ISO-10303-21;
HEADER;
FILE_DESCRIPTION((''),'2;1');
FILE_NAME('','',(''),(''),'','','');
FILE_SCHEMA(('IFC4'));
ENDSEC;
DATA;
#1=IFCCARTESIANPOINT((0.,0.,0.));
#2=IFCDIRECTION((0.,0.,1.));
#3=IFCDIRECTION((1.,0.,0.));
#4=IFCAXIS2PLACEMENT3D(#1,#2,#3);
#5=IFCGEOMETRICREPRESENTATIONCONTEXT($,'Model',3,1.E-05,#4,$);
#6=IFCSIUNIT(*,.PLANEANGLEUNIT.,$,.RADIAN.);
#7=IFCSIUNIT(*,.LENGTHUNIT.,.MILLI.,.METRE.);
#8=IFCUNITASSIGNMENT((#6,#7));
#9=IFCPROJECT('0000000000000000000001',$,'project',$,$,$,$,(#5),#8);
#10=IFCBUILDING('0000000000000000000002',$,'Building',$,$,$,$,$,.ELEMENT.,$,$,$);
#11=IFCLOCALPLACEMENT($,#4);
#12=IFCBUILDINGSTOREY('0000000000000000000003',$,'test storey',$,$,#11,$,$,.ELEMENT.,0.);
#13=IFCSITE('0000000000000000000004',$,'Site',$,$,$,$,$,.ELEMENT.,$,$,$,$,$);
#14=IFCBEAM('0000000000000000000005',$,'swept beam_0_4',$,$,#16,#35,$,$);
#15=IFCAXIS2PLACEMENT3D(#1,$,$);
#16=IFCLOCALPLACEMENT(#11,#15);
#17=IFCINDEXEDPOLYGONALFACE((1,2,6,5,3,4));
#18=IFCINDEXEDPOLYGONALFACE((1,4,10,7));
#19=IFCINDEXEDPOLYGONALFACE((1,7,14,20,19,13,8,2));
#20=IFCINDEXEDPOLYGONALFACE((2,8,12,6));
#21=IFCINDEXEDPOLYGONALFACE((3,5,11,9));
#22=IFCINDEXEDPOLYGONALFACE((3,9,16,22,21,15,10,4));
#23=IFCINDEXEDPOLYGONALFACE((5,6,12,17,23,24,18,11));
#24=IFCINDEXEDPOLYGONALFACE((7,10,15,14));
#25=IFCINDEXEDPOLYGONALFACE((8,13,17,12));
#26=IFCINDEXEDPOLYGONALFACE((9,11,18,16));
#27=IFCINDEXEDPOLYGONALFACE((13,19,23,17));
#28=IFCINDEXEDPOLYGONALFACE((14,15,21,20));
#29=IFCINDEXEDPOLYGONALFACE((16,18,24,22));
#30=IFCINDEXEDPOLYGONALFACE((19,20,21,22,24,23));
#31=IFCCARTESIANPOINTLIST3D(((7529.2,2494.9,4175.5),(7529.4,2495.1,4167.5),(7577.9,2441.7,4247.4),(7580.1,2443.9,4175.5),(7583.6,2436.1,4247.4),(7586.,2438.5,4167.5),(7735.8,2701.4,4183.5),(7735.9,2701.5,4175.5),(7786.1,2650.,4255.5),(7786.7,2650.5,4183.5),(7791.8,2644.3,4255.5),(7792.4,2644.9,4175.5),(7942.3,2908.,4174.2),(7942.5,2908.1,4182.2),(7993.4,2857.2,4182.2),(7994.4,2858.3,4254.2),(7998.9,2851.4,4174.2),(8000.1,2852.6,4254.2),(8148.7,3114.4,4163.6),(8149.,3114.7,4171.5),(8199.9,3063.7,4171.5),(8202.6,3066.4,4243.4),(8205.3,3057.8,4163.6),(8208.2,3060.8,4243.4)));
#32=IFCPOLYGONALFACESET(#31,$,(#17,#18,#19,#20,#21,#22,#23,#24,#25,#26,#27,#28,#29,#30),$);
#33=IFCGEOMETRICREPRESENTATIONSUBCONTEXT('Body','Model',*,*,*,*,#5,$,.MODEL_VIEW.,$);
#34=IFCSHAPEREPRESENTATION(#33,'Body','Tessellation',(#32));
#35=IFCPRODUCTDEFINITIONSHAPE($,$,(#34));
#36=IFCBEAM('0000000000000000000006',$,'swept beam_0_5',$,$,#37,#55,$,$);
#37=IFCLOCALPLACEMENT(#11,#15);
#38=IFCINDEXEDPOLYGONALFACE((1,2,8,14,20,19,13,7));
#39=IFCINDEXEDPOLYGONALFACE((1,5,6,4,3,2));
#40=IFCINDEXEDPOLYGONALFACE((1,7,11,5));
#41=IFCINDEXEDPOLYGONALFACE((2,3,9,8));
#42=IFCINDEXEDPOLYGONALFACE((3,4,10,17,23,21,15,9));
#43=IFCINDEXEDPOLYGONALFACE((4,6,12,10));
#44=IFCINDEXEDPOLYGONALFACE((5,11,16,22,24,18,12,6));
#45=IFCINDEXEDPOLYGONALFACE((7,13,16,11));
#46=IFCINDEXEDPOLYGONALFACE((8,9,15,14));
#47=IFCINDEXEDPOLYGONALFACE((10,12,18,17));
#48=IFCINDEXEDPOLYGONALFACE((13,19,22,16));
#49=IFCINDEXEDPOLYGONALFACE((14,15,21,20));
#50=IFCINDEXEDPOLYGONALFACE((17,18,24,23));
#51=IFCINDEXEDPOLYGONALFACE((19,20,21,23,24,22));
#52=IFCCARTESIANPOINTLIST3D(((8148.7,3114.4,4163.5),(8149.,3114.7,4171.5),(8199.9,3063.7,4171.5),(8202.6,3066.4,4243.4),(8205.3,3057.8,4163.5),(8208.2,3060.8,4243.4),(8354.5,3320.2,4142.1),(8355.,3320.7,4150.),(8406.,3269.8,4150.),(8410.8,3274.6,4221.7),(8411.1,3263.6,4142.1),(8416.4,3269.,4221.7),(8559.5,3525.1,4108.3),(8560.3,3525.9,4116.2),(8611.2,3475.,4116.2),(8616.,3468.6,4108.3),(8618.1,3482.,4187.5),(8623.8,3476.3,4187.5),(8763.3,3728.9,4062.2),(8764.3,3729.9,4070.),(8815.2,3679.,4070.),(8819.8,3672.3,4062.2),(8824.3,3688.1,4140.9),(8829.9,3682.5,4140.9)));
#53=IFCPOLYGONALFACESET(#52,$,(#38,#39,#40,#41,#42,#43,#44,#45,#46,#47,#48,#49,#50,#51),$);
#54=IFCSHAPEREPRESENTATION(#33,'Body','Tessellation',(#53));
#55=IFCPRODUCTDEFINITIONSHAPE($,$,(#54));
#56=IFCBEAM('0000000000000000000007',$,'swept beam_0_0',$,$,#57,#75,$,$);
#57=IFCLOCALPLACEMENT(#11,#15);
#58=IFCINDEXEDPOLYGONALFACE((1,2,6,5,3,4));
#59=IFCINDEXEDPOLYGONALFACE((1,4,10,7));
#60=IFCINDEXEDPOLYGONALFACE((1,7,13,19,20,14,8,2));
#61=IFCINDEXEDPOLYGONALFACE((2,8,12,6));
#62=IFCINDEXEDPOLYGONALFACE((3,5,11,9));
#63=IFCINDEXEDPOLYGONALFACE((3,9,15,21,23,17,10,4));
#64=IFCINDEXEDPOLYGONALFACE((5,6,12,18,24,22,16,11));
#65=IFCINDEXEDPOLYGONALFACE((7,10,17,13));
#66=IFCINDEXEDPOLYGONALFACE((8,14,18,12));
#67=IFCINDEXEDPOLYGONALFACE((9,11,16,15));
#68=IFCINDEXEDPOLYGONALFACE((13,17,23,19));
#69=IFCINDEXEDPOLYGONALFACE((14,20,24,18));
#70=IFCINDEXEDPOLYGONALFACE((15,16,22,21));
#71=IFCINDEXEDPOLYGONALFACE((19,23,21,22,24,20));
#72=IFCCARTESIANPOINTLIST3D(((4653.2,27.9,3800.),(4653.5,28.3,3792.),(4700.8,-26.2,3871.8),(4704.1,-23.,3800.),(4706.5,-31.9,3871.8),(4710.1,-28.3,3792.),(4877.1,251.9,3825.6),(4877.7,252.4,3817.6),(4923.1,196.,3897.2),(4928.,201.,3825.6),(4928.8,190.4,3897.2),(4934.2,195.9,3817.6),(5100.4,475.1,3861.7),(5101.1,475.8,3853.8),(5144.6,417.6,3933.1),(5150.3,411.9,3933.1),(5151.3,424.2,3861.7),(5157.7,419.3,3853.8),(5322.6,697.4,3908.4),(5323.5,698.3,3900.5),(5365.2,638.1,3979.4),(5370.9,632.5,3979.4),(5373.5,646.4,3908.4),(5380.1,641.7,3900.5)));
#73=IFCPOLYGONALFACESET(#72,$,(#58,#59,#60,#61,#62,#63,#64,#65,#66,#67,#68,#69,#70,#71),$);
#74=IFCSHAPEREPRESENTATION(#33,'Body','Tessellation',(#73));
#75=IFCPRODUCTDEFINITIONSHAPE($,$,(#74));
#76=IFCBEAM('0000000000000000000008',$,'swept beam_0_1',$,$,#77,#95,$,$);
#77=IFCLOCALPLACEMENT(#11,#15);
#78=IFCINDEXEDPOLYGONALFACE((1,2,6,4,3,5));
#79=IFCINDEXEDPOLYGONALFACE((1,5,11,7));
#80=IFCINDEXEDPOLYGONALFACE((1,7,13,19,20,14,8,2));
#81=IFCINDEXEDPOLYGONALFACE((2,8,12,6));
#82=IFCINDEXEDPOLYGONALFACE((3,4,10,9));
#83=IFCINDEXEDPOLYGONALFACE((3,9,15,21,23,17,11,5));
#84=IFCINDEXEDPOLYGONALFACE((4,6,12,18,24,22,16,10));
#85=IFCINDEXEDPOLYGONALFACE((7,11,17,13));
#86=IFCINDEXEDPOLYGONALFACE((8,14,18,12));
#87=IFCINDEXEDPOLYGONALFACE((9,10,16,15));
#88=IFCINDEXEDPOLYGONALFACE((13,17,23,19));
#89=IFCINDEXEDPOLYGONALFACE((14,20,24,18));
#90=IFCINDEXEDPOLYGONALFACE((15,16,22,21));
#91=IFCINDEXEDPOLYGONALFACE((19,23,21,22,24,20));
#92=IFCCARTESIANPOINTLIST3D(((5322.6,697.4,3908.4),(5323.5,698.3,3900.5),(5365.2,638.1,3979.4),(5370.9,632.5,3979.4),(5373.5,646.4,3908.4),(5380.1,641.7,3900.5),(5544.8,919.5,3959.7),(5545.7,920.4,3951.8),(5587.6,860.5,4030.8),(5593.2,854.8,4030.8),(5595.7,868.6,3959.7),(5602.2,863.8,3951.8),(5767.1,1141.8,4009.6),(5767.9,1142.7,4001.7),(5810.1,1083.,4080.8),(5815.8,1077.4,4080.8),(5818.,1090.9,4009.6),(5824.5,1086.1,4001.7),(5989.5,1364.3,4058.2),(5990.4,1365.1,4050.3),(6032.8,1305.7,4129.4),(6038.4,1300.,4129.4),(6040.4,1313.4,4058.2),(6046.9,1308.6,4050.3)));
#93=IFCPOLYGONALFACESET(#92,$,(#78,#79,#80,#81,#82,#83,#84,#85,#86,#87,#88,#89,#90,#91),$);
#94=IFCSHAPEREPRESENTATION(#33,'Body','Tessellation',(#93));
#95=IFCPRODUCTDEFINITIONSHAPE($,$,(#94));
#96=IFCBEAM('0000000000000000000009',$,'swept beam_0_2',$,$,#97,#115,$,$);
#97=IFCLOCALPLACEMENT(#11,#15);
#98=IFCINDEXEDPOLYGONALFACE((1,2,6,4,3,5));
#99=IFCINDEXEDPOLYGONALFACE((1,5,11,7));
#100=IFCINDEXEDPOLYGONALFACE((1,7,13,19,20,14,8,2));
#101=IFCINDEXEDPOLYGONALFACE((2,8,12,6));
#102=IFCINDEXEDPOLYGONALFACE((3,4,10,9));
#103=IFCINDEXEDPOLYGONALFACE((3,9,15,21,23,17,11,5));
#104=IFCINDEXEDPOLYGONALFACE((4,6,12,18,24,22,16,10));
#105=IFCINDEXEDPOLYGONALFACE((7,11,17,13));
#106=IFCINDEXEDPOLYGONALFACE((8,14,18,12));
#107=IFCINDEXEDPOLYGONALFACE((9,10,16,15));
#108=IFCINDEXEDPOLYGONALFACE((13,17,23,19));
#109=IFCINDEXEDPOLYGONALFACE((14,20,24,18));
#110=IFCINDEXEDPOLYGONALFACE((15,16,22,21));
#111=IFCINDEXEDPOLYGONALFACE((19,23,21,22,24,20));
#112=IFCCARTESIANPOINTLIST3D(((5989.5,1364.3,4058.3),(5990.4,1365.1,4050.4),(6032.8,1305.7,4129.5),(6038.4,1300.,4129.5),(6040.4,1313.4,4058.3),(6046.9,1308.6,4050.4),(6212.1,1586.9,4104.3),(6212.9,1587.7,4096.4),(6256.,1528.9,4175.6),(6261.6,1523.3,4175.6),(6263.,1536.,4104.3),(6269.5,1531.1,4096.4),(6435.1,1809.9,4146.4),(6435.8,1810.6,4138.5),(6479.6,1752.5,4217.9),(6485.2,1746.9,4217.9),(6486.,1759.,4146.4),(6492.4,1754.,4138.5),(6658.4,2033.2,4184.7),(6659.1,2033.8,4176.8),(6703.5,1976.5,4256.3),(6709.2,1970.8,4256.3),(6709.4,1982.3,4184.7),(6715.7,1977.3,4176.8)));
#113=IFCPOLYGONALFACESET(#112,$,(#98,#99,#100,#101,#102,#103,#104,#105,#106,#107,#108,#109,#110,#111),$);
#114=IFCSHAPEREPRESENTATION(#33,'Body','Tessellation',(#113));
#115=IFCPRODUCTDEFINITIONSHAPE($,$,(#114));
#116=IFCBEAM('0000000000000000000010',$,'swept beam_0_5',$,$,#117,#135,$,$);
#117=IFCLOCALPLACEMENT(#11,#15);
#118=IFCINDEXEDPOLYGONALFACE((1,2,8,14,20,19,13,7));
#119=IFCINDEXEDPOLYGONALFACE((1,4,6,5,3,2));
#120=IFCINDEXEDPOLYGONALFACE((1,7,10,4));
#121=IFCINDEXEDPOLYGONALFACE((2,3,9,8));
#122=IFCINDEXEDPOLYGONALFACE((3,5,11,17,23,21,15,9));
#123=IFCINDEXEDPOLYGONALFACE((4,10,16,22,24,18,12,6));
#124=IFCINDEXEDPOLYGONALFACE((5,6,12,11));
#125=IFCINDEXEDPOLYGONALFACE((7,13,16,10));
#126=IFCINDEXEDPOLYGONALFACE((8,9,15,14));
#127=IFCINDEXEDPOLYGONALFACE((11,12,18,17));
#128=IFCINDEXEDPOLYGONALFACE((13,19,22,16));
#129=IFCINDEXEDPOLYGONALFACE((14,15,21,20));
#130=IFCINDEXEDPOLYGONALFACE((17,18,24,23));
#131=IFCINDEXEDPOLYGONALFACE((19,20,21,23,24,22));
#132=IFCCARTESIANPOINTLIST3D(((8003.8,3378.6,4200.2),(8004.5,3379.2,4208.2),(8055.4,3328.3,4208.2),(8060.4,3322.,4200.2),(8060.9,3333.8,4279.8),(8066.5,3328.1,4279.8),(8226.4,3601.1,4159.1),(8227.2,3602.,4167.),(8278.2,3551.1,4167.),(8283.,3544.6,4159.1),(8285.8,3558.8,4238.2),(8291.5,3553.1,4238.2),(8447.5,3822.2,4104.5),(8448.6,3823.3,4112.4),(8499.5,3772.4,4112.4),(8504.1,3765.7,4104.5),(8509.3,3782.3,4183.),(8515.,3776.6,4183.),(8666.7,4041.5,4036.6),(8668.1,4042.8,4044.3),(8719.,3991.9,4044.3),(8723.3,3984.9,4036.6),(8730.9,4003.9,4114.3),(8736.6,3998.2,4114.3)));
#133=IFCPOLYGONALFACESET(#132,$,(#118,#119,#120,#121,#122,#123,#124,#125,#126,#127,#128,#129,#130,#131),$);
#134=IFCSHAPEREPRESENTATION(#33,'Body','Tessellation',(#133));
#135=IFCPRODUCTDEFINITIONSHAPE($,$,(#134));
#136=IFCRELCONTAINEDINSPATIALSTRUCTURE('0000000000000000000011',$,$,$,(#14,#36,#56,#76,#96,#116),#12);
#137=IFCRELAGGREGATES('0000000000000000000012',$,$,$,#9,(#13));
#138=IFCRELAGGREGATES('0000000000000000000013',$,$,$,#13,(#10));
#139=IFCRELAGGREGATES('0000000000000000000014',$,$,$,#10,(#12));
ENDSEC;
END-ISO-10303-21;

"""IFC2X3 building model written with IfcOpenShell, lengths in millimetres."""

from ifc_helpers import new_model, entity, si_unit, origin_with_axes, place, context, subcontext, project, spatial, element, save


model = new_model("IFC2X3")

# Units and contexts
model_context = context("Model", 3, precision=1e-05, world=origin_with_axes())
body_context = subcontext(model_context, "Body", "Model", "MODEL_VIEW")
ifc_project = project(units=[si_unit("PLANEANGLEUNIT", "RADIAN"), si_unit("LENGTHUNIT", "METRE", prefix="MILLI")], contexts=[model_context])

# Site, building, storey
site = spatial("IfcSite", under=ifc_project, Name="Site", CompositionType="ELEMENT")
building = spatial("IfcBuilding", under=site, Name="Building", CompositionType="ELEMENT")
storey_placement = place(None, origin_with_axes())
storey = spatial("IfcBuildingStorey", under=building, at=storey_placement, Name="test storey", CompositionType="ELEMENT", Elevation=0.0)

# Beams
beam_1_placement = place(storey_placement, origin_with_axes())
element("IfcBeam", 1, at=beam_1_placement, inside=storey, Name="swept beam_0_4", context=body_context, shape_type="SweptSolid", body=[
    entity("IfcRevolvedAreaSolid", entity("IfcArbitraryClosedProfileDef", "AREA", None, entity("IfcPolyline", [entity("IfcCartesianPoint", [80.0, -40.0]), entity("IfcCartesianPoint", [80.0, -32.0]), entity("IfcCartesianPoint", [8.0, -32.0]), entity("IfcCartesianPoint", [8.0, 40.0]), entity("IfcCartesianPoint", [0.0, 40.0]), entity("IfcCartesianPoint", [0.0, -40.0]), entity("IfcCartesianPoint", [80.0, -40.0])])), entity("IfcAxis2Placement3D", entity("IfcCartesianPoint", [7557.7, 2466.8, 4167.5]), entity("IfcDirection", [-0.7064, -0.7064, -0.0434]), entity("IfcDirection", [-0.0307, -0.0307, 0.9991])), entity("IfcAxis1Placement", entity("IfcCartesianPoint", [-9138.7, 0.0, 0.0]), entity("IfcDirection", [0.0, 1.0, 0.0])), 0.095868),
])
beam_2_placement = place(storey_placement, origin_with_axes())
element("IfcBeam", 2, at=beam_2_placement, inside=storey, Name="swept beam_0_5", context=body_context, shape_type="SweptSolid", body=[
    entity("IfcRevolvedAreaSolid", entity("IfcArbitraryClosedProfileDef", "AREA", None, entity("IfcPolyline", [entity("IfcCartesianPoint", [80.0, -40.0]), entity("IfcCartesianPoint", [80.0, -32.0]), entity("IfcCartesianPoint", [8.0, -32.0]), entity("IfcCartesianPoint", [8.0, 40.0]), entity("IfcCartesianPoint", [0.0, 40.0]), entity("IfcCartesianPoint", [0.0, -40.0]), entity("IfcCartesianPoint", [80.0, -40.0])])), entity("IfcAxis2Placement3D", entity("IfcCartesianPoint", [8177.0, 3086.1, 4163.5]), entity("IfcDirection", [-0.7061, -0.7061, 0.0524]), entity("IfcDirection", [0.0371, 0.0371, 0.9986])), entity("IfcAxis1Placement", entity("IfcCartesianPoint", [-6874.3, 0.0, 0.0]), entity("IfcDirection", [0.0, 1.0, 0.0])), 0.127373),
])
beam_3_placement = place(storey_placement, origin_with_axes())
element("IfcBeam", 3, at=beam_3_placement, inside=storey, Name="swept beam_0_0", context=body_context, shape_type="SweptSolid", body=[
    entity("IfcRevolvedAreaSolid", entity("IfcArbitraryClosedProfileDef", "AREA", None, entity("IfcPolyline", [entity("IfcCartesianPoint", [-80.0, 40.0]), entity("IfcCartesianPoint", [-80.0, 32.0]), entity("IfcCartesianPoint", [-8.0, 32.0]), entity("IfcCartesianPoint", [-8.0, -40.0]), entity("IfcCartesianPoint", [0.0, -40.0]), entity("IfcCartesianPoint", [0.0, 40.0]), entity("IfcCartesianPoint", [-80.0, 40.0])])), entity("IfcAxis2Placement3D", entity("IfcCartesianPoint", [4681.8, 0.0, 3792.0]), entity("IfcDirection", [-0.7057, -0.7057, -0.0639]), entity("IfcDirection", [0.0452, 0.0452, -0.998])), entity("IfcAxis1Placement", entity("IfcCartesianPoint", [-9527.9, 0.0, 0.0]), entity("IfcDirection", [0.0, 1.0, 0.0])), 0.100138),
])
beam_4_placement = place(storey_placement, origin_with_axes())
element("IfcBeam", 4, at=beam_4_placement, inside=storey, Name="swept beam_0_1", context=body_context, shape_type="SweptSolid", body=[
    entity("IfcRevolvedAreaSolid", entity("IfcArbitraryClosedProfileDef", "AREA", None, entity("IfcPolyline", [entity("IfcCartesianPoint", [80.0, -40.0]), entity("IfcCartesianPoint", [80.0, -32.0]), entity("IfcCartesianPoint", [8.0, -32.0]), entity("IfcCartesianPoint", [8.0, 40.0]), entity("IfcCartesianPoint", [0.0, 40.0]), entity("IfcCartesianPoint", [0.0, -40.0]), entity("IfcCartesianPoint", [80.0, -40.0])])), entity("IfcAxis2Placement3D", entity("IfcCartesianPoint", [5351.8, 670.0, 3900.5]), entity("IfcDirection", [-0.6976, -0.6976, -0.1633]), entity("IfcDirection", [-0.1155, -0.1155, 0.9866])), entity("IfcAxis1Placement", entity("IfcCartesianPoint", [-73972.0, 0.0, 0.0]), entity("IfcDirection", [0.0, 1.0, 0.0])), 0.012909),
])
beam_5_placement = place(storey_placement, origin_with_axes())
element("IfcBeam", 5, at=beam_5_placement, inside=storey, Name="swept beam_0_2", context=body_context, shape_type="SweptSolid", body=[
    entity("IfcRevolvedAreaSolid", entity("IfcArbitraryClosedProfileDef", "AREA", None, entity("IfcPolyline", [entity("IfcCartesianPoint", [80.0, -40.0]), entity("IfcCartesianPoint", [80.0, -32.0]), entity("IfcCartesianPoint", [8.0, -32.0]), entity("IfcCartesianPoint", [8.0, 40.0]), entity("IfcCartesianPoint", [0.0, 40.0]), entity("IfcCartesianPoint", [0.0, -40.0]), entity("IfcCartesianPoint", [80.0, -40.0])])), entity("IfcAxis2Placement3D", entity("IfcCartesianPoint", [6018.7, 1336.8, 4050.4]), entity("IfcDirection", [-0.699, -0.699, -0.1506]), entity("IfcDirection", [-0.1065, -0.1065, 0.9886])), entity("IfcAxis1Placement", entity("IfcCartesianPoint", [-26074.9, 0.0, 0.0]), entity("IfcDirection", [0.0, 1.0, 0.0])), 0.036594),
])
beam_6_placement = place(storey_placement, origin_with_axes())
element("IfcBeam", 6, at=beam_6_placement, inside=storey, Name="swept beam_0_5", context=body_context, shape_type="SweptSolid", body=[
    entity("IfcRevolvedAreaSolid", entity("IfcArbitraryClosedProfileDef", "AREA", None, entity("IfcPolyline", [entity("IfcCartesianPoint", [80.0, -40.0]), entity("IfcCartesianPoint", [80.0, -32.0]), entity("IfcCartesianPoint", [8.0, -32.0]), entity("IfcCartesianPoint", [8.0, 40.0]), entity("IfcCartesianPoint", [0.0, 40.0]), entity("IfcCartesianPoint", [0.0, -40.0]), entity("IfcCartesianPoint", [80.0, -40.0])])), entity("IfcAxis2Placement3D", entity("IfcCartesianPoint", [8032.1, 3350.3, 4200.2]), entity("IfcDirection", [-0.703, -0.703, 0.1082]), entity("IfcDirection", [0.0765, 0.0765, 0.9941])), entity("IfcAxis1Placement", entity("IfcCartesianPoint", [-7389.4, 0.0, 0.0]), entity("IfcDirection", [0.0, 1.0, 0.0])), 0.128873),
])

save(model, "model.ifc")
